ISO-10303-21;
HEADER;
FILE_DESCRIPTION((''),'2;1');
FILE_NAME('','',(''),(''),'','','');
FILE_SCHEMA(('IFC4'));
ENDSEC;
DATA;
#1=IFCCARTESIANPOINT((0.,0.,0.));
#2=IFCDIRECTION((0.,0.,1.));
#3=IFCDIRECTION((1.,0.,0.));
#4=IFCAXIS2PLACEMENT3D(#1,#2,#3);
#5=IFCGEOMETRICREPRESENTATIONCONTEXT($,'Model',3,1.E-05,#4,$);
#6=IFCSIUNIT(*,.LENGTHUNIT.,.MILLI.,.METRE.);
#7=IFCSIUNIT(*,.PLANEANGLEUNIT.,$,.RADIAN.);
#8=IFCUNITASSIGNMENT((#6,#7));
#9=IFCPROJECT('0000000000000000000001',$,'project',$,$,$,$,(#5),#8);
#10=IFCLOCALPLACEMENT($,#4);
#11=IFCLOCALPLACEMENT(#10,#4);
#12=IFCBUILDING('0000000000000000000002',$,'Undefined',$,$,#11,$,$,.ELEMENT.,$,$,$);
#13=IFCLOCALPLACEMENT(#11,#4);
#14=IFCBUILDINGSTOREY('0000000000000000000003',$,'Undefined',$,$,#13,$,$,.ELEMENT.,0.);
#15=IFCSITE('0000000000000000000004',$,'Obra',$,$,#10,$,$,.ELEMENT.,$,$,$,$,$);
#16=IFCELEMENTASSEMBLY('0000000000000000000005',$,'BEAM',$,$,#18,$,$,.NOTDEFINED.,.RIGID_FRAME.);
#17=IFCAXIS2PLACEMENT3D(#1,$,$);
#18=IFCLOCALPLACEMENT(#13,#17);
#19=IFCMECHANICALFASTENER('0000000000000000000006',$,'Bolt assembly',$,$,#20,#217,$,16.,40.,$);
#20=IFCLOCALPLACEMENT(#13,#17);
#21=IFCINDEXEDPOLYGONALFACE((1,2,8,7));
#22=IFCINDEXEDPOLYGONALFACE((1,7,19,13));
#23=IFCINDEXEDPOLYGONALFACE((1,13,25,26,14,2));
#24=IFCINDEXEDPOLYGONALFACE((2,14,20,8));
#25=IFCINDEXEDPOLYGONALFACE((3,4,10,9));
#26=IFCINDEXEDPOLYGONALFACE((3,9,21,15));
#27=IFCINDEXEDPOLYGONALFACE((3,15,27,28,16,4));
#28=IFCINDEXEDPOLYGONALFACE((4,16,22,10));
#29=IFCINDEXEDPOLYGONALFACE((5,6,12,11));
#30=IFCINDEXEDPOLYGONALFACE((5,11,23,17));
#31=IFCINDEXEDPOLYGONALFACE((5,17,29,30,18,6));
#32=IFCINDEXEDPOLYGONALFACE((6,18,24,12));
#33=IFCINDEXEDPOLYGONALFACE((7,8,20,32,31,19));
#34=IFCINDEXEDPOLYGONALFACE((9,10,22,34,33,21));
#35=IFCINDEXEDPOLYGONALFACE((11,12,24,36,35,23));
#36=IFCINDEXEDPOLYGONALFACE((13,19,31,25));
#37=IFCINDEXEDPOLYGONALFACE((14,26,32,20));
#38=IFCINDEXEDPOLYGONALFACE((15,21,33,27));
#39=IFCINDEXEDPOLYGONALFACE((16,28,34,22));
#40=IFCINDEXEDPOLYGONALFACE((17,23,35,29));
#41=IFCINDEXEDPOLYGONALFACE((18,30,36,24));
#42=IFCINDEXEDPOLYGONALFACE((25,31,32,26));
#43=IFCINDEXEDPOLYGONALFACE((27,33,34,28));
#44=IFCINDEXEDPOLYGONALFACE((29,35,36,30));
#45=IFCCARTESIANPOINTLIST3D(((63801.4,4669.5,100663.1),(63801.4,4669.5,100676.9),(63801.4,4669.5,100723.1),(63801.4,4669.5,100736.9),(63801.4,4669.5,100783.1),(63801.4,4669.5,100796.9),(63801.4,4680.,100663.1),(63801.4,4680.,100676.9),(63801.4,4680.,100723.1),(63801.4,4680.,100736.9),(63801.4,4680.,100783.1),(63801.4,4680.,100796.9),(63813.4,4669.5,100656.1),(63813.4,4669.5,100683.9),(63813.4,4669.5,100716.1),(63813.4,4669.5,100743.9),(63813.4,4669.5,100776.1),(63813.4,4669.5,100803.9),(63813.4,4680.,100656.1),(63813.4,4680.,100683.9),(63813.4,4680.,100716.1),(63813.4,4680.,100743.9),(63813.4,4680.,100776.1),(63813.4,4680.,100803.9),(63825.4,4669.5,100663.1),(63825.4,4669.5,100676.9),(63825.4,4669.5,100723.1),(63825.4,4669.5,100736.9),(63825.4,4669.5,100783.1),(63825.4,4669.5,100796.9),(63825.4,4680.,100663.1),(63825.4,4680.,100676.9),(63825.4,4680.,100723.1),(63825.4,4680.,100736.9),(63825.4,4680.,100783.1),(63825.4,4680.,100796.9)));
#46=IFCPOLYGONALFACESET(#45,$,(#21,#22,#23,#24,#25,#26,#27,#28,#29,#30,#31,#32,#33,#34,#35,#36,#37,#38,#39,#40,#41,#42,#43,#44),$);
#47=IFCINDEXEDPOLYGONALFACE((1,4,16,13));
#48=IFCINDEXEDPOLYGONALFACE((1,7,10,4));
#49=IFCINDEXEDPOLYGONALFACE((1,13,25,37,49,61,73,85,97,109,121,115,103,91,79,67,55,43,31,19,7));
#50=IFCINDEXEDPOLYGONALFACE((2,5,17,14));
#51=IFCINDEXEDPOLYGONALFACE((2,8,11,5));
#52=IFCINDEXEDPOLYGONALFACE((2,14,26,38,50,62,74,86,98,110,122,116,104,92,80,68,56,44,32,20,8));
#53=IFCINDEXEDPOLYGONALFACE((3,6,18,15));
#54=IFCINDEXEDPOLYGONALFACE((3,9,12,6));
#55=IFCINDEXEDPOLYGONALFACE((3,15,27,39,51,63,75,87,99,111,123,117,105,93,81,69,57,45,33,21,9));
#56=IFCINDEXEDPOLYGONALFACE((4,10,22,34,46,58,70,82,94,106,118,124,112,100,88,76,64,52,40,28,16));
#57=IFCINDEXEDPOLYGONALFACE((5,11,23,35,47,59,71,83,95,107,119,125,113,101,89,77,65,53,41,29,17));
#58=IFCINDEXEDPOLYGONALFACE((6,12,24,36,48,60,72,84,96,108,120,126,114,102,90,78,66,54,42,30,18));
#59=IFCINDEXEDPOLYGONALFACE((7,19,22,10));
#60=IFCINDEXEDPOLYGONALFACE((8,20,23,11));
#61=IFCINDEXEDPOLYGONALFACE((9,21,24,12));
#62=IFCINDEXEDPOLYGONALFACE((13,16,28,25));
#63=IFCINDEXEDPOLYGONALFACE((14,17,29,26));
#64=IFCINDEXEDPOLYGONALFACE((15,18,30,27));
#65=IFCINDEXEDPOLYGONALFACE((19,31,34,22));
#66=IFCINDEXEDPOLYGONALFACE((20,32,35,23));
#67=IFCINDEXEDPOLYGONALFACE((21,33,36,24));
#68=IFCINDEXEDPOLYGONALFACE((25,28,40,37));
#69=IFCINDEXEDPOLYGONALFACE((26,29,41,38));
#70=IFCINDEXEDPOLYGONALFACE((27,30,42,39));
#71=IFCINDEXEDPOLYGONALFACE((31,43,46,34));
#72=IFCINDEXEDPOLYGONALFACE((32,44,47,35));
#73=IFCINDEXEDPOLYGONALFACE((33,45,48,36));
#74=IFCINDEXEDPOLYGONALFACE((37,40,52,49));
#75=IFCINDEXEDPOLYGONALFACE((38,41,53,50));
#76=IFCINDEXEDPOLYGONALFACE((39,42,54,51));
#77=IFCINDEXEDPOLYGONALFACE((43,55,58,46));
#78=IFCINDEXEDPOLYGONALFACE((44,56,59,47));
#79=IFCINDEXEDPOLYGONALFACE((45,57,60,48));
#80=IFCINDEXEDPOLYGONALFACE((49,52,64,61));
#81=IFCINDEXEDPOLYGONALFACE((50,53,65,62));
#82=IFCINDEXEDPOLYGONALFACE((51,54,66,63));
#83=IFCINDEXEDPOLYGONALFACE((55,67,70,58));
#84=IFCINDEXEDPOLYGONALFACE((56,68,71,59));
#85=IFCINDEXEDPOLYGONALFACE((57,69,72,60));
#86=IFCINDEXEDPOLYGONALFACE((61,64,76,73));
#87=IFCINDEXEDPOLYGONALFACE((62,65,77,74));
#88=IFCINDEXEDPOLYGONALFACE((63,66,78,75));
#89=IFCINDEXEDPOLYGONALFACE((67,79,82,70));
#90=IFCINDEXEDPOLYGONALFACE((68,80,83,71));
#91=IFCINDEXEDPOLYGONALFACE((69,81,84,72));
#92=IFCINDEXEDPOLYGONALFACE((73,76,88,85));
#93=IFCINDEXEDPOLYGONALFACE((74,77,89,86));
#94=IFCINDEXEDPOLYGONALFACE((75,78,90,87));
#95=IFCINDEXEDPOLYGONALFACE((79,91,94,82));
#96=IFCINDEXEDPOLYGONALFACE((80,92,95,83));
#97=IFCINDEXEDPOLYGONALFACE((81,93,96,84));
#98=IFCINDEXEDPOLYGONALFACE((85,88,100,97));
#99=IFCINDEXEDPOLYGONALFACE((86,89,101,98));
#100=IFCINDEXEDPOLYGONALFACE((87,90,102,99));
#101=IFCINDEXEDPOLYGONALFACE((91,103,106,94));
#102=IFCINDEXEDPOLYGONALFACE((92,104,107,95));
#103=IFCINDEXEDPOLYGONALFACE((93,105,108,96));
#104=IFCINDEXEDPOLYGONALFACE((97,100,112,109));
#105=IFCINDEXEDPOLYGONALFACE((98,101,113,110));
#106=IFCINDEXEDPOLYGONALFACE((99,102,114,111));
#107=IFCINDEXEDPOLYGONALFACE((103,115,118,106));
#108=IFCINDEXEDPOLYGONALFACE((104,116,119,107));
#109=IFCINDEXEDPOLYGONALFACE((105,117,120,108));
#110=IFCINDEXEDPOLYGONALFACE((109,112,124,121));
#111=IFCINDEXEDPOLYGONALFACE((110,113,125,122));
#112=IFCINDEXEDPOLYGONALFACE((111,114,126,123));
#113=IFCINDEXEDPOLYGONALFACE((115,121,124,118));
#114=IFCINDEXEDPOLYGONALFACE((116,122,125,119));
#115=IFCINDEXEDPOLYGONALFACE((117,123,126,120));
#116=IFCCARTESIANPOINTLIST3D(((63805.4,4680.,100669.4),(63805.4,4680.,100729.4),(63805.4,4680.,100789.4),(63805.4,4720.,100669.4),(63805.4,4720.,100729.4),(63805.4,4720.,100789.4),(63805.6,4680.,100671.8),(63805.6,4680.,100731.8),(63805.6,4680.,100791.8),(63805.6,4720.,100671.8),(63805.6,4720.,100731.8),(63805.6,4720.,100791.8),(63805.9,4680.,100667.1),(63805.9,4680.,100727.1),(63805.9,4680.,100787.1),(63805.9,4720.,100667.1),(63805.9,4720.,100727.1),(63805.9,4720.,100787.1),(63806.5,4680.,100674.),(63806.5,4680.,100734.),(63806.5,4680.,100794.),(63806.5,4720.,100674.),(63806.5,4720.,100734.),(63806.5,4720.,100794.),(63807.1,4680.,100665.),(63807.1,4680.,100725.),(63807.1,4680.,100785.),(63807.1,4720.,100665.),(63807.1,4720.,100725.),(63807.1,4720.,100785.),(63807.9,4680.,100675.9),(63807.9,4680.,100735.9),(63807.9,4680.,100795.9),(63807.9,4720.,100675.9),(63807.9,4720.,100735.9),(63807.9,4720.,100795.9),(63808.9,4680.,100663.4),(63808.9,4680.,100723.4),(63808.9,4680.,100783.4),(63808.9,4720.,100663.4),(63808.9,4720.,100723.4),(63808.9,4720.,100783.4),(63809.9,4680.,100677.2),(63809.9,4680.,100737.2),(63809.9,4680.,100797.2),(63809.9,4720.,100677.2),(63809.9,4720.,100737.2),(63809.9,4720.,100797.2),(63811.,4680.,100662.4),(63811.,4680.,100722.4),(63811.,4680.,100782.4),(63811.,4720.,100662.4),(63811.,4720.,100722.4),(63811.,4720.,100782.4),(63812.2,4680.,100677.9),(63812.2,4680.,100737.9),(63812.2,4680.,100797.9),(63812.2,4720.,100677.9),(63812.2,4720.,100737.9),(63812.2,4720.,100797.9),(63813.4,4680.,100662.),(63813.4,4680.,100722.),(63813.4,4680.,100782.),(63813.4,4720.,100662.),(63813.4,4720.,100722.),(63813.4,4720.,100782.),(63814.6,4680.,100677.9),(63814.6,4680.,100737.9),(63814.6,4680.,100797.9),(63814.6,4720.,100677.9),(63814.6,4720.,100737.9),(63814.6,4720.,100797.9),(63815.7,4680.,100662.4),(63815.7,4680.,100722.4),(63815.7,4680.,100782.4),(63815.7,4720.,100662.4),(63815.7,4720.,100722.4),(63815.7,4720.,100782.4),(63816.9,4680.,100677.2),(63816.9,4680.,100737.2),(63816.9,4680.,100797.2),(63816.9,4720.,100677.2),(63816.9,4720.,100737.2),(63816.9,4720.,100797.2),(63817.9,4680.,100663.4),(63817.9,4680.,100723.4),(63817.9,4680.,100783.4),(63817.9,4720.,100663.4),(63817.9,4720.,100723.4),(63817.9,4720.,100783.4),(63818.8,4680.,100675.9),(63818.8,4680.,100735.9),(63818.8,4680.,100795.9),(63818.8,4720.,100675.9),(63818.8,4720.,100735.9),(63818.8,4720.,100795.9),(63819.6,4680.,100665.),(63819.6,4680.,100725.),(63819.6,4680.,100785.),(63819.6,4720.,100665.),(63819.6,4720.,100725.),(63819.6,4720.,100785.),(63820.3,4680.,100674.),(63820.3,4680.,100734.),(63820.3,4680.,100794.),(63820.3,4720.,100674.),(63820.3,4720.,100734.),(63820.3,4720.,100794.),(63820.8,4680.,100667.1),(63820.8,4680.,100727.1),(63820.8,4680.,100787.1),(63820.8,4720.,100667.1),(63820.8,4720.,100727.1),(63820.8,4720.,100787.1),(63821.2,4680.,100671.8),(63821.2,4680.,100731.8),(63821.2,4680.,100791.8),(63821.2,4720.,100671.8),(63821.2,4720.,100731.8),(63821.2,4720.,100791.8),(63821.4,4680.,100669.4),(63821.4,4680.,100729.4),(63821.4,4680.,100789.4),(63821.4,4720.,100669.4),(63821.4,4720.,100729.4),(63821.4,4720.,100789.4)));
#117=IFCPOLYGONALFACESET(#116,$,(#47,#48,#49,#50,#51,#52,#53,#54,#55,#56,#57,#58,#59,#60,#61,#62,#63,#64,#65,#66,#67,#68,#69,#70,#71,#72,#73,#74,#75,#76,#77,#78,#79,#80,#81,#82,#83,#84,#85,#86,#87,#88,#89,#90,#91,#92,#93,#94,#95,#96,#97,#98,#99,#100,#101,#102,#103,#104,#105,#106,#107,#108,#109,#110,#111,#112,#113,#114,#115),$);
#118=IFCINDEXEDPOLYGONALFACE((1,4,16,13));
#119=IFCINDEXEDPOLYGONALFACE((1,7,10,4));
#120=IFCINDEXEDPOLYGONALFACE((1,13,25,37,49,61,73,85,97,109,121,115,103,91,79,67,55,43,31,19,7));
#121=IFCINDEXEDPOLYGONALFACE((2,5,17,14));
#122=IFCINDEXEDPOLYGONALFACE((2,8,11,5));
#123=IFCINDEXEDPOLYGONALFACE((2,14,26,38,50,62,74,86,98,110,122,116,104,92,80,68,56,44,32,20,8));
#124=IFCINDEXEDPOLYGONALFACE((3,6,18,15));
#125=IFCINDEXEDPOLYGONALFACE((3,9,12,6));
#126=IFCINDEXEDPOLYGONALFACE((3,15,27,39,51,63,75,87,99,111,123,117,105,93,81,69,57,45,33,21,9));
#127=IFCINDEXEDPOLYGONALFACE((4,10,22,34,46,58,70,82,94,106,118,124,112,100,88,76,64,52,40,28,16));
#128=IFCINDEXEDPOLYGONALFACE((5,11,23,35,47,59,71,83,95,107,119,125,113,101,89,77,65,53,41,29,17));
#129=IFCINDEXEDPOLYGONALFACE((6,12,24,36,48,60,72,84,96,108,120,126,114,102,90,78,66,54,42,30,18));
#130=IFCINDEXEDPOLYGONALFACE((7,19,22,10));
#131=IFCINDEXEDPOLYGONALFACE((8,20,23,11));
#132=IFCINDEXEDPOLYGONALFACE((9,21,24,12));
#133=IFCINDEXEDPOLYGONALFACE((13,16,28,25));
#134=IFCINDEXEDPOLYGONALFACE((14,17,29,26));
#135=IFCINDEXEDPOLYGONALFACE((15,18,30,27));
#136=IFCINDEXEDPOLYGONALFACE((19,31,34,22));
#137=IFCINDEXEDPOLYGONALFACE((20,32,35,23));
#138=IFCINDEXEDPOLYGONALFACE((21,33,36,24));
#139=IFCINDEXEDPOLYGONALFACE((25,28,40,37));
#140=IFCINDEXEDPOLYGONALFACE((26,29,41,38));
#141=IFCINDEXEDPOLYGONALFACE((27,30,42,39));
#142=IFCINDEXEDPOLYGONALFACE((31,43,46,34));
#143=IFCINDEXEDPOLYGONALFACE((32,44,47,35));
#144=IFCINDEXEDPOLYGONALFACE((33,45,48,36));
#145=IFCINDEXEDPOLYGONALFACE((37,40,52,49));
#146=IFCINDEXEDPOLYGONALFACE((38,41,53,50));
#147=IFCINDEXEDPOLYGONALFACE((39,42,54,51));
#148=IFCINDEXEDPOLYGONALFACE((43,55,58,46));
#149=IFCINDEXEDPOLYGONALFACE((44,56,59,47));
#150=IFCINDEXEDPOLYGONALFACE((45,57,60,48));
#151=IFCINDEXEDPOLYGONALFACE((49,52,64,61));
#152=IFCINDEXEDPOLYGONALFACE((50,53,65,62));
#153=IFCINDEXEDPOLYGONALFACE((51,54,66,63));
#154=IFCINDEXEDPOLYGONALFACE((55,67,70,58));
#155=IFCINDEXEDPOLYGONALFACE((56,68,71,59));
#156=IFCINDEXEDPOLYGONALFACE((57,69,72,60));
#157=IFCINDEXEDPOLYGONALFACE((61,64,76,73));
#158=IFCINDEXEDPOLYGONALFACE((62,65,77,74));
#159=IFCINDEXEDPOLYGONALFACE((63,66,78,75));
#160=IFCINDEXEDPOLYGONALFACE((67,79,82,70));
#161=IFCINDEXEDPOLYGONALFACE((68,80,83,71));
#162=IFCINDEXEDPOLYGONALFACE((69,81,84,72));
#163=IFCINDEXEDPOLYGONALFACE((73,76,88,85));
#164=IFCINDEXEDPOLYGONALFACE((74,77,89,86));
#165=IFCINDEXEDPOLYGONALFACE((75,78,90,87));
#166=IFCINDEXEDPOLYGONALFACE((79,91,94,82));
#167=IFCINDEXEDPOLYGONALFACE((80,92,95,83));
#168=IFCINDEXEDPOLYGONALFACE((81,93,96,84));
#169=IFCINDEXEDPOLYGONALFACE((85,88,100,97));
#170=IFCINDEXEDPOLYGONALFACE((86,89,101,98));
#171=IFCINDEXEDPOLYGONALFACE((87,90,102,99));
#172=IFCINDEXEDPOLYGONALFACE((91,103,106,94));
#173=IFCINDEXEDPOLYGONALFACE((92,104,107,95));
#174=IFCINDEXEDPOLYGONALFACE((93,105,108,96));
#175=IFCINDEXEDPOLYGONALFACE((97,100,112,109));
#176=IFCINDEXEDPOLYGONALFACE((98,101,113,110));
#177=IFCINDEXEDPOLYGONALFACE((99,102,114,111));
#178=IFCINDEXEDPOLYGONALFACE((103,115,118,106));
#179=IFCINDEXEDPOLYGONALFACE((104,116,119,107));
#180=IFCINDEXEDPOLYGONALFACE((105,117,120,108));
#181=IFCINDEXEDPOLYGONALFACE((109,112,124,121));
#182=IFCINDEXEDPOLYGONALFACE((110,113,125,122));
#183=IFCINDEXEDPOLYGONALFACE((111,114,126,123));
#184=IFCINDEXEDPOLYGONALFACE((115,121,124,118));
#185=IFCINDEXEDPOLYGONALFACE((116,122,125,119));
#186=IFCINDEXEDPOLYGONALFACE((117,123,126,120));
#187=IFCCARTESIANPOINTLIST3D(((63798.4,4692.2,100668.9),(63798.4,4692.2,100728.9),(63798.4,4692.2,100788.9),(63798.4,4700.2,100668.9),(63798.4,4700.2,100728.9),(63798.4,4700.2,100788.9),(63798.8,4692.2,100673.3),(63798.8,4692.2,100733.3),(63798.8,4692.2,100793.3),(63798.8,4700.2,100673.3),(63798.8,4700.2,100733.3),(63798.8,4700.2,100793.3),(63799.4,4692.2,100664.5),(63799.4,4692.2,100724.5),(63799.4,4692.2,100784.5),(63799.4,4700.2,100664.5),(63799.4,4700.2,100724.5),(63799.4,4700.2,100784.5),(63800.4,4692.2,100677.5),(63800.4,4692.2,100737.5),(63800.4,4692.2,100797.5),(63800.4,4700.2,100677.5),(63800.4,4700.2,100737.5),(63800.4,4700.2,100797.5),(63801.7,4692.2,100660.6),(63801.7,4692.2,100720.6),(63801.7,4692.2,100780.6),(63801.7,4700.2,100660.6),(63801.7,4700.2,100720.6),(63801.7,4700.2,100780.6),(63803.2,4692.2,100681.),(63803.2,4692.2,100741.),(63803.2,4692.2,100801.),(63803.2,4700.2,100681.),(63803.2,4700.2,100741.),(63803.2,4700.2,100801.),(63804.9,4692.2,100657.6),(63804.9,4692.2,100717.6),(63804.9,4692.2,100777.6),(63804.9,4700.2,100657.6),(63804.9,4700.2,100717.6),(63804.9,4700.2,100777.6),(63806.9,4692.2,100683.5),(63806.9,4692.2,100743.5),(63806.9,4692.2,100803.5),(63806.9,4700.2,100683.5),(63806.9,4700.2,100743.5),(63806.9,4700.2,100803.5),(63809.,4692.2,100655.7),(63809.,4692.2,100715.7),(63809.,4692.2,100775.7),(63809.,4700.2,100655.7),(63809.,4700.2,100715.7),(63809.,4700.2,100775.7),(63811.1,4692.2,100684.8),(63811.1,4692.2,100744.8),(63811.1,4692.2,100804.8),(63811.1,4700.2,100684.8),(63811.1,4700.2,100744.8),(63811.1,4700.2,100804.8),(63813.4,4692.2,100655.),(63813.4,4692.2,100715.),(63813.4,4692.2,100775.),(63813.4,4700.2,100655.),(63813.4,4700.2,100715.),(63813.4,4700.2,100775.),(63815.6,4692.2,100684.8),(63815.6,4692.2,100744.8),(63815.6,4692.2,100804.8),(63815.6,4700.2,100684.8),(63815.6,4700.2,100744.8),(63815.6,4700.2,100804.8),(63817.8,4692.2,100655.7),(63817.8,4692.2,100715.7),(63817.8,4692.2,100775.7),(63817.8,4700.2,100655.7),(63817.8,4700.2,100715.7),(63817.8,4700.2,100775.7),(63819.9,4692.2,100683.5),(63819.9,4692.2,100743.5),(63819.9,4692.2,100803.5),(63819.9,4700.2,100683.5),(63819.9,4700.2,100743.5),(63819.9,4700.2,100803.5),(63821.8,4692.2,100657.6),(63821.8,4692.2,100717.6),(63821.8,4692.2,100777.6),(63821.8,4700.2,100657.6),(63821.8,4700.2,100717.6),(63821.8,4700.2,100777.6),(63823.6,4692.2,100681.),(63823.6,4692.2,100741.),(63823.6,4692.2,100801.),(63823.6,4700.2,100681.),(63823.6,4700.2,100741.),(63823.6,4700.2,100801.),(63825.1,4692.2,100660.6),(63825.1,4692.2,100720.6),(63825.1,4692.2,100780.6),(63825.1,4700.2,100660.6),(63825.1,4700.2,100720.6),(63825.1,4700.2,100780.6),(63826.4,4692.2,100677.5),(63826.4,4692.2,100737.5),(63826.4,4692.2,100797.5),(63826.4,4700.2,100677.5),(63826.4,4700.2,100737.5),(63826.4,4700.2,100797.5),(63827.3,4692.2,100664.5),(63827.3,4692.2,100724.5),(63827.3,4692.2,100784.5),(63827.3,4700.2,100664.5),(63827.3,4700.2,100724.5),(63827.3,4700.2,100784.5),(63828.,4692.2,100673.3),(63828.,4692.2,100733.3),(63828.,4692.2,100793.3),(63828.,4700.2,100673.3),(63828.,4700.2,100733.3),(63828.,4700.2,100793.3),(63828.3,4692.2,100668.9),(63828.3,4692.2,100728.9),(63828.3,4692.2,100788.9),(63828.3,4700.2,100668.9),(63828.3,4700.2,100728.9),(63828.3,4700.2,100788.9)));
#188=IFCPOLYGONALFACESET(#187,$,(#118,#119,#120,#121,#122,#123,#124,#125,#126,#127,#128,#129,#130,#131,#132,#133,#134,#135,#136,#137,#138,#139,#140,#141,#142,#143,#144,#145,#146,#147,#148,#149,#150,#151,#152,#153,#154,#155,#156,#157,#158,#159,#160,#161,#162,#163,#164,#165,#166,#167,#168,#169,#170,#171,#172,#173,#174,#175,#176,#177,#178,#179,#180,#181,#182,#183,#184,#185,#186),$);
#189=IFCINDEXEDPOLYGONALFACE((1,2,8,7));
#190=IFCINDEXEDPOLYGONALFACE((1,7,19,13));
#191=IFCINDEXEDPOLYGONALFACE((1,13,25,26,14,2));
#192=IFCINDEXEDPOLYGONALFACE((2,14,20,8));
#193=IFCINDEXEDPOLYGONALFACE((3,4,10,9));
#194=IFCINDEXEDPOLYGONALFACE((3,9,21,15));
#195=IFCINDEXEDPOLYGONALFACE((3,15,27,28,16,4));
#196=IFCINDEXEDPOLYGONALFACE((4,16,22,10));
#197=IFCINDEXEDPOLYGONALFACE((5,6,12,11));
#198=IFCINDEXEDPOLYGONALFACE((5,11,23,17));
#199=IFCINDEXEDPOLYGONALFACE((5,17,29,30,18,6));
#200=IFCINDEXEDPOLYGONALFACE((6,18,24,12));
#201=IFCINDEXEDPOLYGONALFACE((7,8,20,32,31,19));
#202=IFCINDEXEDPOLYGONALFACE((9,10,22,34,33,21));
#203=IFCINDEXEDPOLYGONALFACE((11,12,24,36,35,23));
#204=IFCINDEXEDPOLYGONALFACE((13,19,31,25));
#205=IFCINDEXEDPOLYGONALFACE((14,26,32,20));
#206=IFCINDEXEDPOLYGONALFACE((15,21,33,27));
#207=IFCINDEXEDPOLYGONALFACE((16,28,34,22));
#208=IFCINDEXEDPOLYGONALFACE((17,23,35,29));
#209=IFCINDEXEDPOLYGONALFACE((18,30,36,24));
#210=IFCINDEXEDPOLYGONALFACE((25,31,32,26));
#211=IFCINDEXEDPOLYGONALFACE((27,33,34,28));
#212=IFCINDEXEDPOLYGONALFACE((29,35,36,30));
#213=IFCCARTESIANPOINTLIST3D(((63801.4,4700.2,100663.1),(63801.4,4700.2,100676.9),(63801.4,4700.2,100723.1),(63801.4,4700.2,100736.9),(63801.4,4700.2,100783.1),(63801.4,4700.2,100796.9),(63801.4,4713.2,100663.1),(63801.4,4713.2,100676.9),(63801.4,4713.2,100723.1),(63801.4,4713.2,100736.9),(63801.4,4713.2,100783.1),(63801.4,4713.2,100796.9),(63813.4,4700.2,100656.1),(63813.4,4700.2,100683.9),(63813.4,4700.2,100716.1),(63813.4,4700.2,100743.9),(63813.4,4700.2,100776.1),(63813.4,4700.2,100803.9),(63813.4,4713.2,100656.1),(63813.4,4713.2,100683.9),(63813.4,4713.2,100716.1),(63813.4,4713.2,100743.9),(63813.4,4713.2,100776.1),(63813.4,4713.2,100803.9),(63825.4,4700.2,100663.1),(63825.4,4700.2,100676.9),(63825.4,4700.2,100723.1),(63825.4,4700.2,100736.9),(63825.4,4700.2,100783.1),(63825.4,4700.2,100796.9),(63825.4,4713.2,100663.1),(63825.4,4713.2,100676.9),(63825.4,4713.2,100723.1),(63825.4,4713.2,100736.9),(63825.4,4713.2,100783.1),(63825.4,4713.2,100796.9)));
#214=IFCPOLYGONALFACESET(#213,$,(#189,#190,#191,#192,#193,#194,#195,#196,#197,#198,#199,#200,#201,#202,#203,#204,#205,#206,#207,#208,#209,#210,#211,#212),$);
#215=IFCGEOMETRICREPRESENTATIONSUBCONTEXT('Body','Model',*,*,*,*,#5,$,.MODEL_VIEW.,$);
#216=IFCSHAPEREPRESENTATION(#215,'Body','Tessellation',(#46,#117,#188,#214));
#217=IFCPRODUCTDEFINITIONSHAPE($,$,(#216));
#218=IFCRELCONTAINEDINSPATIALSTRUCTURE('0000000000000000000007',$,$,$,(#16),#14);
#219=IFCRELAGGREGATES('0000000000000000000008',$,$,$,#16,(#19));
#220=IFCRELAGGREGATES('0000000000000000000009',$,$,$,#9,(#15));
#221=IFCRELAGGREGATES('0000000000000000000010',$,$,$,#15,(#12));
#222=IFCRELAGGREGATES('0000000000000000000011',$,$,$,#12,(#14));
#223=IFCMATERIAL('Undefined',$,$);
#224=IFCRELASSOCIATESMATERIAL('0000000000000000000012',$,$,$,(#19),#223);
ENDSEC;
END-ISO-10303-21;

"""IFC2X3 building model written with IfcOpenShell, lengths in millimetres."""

from ifc_helpers import new_model, si_unit, frame, origin_with_axes, origin_2d_with_axis, place, context, subcontext, project, spatial, polyline, circle, outline, extrude, source, transform, mapped, material, element, aggregate, save


model = new_model("IFC2X3")

# Units and contexts
model_context = context("Model", 3, precision=1e-05, world=origin_with_axes())
body_context = subcontext(model_context, "Body", "Model", "MODEL_VIEW")
ifc_project = project(units=[si_unit("LENGTHUNIT", "METRE", prefix="MILLI"), si_unit("PLANEANGLEUNIT", "RADIAN")], contexts=[model_context])

# Site, building, storey
site_placement = place(None, origin_with_axes())
site = spatial("IfcSite", under=ifc_project, at=site_placement, Name="Obra", CompositionType="ELEMENT")
building_placement = place(site_placement, origin_with_axes())
building = spatial("IfcBuilding", under=site, at=building_placement, Name="Undefined", CompositionType="ELEMENT")
storey_placement = place(building_placement, origin_with_axes())
storey = spatial("IfcBuildingStorey", under=building, at=storey_placement, Name="Undefined", CompositionType="ELEMENT", Elevation=0.0)

# Shared definitions
ifc_material_1 = material(Name="Undefined")

# Shared definitions
shared_shape_1 = source(origin_with_axes(), body_context, "Body", "SweptSolid", [
    extrude(outline(polyline([(13.9, 0.0), (6.9, 12.0), (-6.9, 12.0), (-13.9, 0.0), (-6.9, -12.0), (6.9, -12.0), (13.9, 0.0)])), frame((0.0, -19.7, 0.0), z_axis=(0.0, 1.0, 0.0), x_axis=(1.0, 0.0, 0.0)), (0.0, 0.0, 1.0), 10.6),
    extrude(circle(Radius=8.0, at=origin_2d_with_axis()), frame((0.0, -9.1, 0.0), z_axis=(0.0, 1.0, 0.0), x_axis=(1.0, 0.0, 0.0)), (0.0, 0.0, 1.0), 40.0),
    extrude(circle(Radius=15.0, at=origin_2d_with_axis()), frame((0.0, 3.1, 0.0), z_axis=(0.0, 1.0, 0.0), x_axis=(1.0, 0.0, 0.0)), (0.0, 0.0, 1.0), 8.0),
    extrude(outline(polyline([(13.9, 0.0), (6.9, 12.0), (-6.9, 12.0), (-13.9, 0.0), (-6.9, -12.0), (6.9, -12.0), (13.9, 0.0)])), frame((0.0, 11.1, 0.0), z_axis=(0.0, 1.0, 0.0), x_axis=(1.0, 0.0, 0.0)), (0.0, 0.0, 1.0), 13.0),
])

# Element assembly, mechanical fastener
assembly_1_placement = place(storey_placement, origin_with_axes())
assembly_1 = element("IfcElementAssembly", 1, at=assembly_1_placement, inside=storey, Name="BEAM", AssemblyPlace="NOTDEFINED", PredefinedType="RIGID_FRAME")
mechanical_fastener_1_placement = place(assembly_1_placement, frame((63763.4, 4689.1, 100850.0), z_axis=(1.0, 0.0, 0.0), x_axis=(0.0, 0.0, -1.0)))
mechanical_fastener_1 = element("IfcMechanicalFastener", 2, at=mechanical_fastener_1_placement, material=ifc_material_1, Name="Bolt assembly", NominalDiameter=16.0, NominalLength=40.0, context=body_context, shape_type="MappedRepresentation", body=[
    mapped(shared_shape_1, transform((60.0, 0.0, 50.0))),
    mapped(shared_shape_1, transform((120.0, 0.0, 50.0))),
    mapped(shared_shape_1, transform((180.0, 0.0, 50.0))),
])
aggregate(assembly_1, [mechanical_fastener_1])

save(model, "model.ifc")
